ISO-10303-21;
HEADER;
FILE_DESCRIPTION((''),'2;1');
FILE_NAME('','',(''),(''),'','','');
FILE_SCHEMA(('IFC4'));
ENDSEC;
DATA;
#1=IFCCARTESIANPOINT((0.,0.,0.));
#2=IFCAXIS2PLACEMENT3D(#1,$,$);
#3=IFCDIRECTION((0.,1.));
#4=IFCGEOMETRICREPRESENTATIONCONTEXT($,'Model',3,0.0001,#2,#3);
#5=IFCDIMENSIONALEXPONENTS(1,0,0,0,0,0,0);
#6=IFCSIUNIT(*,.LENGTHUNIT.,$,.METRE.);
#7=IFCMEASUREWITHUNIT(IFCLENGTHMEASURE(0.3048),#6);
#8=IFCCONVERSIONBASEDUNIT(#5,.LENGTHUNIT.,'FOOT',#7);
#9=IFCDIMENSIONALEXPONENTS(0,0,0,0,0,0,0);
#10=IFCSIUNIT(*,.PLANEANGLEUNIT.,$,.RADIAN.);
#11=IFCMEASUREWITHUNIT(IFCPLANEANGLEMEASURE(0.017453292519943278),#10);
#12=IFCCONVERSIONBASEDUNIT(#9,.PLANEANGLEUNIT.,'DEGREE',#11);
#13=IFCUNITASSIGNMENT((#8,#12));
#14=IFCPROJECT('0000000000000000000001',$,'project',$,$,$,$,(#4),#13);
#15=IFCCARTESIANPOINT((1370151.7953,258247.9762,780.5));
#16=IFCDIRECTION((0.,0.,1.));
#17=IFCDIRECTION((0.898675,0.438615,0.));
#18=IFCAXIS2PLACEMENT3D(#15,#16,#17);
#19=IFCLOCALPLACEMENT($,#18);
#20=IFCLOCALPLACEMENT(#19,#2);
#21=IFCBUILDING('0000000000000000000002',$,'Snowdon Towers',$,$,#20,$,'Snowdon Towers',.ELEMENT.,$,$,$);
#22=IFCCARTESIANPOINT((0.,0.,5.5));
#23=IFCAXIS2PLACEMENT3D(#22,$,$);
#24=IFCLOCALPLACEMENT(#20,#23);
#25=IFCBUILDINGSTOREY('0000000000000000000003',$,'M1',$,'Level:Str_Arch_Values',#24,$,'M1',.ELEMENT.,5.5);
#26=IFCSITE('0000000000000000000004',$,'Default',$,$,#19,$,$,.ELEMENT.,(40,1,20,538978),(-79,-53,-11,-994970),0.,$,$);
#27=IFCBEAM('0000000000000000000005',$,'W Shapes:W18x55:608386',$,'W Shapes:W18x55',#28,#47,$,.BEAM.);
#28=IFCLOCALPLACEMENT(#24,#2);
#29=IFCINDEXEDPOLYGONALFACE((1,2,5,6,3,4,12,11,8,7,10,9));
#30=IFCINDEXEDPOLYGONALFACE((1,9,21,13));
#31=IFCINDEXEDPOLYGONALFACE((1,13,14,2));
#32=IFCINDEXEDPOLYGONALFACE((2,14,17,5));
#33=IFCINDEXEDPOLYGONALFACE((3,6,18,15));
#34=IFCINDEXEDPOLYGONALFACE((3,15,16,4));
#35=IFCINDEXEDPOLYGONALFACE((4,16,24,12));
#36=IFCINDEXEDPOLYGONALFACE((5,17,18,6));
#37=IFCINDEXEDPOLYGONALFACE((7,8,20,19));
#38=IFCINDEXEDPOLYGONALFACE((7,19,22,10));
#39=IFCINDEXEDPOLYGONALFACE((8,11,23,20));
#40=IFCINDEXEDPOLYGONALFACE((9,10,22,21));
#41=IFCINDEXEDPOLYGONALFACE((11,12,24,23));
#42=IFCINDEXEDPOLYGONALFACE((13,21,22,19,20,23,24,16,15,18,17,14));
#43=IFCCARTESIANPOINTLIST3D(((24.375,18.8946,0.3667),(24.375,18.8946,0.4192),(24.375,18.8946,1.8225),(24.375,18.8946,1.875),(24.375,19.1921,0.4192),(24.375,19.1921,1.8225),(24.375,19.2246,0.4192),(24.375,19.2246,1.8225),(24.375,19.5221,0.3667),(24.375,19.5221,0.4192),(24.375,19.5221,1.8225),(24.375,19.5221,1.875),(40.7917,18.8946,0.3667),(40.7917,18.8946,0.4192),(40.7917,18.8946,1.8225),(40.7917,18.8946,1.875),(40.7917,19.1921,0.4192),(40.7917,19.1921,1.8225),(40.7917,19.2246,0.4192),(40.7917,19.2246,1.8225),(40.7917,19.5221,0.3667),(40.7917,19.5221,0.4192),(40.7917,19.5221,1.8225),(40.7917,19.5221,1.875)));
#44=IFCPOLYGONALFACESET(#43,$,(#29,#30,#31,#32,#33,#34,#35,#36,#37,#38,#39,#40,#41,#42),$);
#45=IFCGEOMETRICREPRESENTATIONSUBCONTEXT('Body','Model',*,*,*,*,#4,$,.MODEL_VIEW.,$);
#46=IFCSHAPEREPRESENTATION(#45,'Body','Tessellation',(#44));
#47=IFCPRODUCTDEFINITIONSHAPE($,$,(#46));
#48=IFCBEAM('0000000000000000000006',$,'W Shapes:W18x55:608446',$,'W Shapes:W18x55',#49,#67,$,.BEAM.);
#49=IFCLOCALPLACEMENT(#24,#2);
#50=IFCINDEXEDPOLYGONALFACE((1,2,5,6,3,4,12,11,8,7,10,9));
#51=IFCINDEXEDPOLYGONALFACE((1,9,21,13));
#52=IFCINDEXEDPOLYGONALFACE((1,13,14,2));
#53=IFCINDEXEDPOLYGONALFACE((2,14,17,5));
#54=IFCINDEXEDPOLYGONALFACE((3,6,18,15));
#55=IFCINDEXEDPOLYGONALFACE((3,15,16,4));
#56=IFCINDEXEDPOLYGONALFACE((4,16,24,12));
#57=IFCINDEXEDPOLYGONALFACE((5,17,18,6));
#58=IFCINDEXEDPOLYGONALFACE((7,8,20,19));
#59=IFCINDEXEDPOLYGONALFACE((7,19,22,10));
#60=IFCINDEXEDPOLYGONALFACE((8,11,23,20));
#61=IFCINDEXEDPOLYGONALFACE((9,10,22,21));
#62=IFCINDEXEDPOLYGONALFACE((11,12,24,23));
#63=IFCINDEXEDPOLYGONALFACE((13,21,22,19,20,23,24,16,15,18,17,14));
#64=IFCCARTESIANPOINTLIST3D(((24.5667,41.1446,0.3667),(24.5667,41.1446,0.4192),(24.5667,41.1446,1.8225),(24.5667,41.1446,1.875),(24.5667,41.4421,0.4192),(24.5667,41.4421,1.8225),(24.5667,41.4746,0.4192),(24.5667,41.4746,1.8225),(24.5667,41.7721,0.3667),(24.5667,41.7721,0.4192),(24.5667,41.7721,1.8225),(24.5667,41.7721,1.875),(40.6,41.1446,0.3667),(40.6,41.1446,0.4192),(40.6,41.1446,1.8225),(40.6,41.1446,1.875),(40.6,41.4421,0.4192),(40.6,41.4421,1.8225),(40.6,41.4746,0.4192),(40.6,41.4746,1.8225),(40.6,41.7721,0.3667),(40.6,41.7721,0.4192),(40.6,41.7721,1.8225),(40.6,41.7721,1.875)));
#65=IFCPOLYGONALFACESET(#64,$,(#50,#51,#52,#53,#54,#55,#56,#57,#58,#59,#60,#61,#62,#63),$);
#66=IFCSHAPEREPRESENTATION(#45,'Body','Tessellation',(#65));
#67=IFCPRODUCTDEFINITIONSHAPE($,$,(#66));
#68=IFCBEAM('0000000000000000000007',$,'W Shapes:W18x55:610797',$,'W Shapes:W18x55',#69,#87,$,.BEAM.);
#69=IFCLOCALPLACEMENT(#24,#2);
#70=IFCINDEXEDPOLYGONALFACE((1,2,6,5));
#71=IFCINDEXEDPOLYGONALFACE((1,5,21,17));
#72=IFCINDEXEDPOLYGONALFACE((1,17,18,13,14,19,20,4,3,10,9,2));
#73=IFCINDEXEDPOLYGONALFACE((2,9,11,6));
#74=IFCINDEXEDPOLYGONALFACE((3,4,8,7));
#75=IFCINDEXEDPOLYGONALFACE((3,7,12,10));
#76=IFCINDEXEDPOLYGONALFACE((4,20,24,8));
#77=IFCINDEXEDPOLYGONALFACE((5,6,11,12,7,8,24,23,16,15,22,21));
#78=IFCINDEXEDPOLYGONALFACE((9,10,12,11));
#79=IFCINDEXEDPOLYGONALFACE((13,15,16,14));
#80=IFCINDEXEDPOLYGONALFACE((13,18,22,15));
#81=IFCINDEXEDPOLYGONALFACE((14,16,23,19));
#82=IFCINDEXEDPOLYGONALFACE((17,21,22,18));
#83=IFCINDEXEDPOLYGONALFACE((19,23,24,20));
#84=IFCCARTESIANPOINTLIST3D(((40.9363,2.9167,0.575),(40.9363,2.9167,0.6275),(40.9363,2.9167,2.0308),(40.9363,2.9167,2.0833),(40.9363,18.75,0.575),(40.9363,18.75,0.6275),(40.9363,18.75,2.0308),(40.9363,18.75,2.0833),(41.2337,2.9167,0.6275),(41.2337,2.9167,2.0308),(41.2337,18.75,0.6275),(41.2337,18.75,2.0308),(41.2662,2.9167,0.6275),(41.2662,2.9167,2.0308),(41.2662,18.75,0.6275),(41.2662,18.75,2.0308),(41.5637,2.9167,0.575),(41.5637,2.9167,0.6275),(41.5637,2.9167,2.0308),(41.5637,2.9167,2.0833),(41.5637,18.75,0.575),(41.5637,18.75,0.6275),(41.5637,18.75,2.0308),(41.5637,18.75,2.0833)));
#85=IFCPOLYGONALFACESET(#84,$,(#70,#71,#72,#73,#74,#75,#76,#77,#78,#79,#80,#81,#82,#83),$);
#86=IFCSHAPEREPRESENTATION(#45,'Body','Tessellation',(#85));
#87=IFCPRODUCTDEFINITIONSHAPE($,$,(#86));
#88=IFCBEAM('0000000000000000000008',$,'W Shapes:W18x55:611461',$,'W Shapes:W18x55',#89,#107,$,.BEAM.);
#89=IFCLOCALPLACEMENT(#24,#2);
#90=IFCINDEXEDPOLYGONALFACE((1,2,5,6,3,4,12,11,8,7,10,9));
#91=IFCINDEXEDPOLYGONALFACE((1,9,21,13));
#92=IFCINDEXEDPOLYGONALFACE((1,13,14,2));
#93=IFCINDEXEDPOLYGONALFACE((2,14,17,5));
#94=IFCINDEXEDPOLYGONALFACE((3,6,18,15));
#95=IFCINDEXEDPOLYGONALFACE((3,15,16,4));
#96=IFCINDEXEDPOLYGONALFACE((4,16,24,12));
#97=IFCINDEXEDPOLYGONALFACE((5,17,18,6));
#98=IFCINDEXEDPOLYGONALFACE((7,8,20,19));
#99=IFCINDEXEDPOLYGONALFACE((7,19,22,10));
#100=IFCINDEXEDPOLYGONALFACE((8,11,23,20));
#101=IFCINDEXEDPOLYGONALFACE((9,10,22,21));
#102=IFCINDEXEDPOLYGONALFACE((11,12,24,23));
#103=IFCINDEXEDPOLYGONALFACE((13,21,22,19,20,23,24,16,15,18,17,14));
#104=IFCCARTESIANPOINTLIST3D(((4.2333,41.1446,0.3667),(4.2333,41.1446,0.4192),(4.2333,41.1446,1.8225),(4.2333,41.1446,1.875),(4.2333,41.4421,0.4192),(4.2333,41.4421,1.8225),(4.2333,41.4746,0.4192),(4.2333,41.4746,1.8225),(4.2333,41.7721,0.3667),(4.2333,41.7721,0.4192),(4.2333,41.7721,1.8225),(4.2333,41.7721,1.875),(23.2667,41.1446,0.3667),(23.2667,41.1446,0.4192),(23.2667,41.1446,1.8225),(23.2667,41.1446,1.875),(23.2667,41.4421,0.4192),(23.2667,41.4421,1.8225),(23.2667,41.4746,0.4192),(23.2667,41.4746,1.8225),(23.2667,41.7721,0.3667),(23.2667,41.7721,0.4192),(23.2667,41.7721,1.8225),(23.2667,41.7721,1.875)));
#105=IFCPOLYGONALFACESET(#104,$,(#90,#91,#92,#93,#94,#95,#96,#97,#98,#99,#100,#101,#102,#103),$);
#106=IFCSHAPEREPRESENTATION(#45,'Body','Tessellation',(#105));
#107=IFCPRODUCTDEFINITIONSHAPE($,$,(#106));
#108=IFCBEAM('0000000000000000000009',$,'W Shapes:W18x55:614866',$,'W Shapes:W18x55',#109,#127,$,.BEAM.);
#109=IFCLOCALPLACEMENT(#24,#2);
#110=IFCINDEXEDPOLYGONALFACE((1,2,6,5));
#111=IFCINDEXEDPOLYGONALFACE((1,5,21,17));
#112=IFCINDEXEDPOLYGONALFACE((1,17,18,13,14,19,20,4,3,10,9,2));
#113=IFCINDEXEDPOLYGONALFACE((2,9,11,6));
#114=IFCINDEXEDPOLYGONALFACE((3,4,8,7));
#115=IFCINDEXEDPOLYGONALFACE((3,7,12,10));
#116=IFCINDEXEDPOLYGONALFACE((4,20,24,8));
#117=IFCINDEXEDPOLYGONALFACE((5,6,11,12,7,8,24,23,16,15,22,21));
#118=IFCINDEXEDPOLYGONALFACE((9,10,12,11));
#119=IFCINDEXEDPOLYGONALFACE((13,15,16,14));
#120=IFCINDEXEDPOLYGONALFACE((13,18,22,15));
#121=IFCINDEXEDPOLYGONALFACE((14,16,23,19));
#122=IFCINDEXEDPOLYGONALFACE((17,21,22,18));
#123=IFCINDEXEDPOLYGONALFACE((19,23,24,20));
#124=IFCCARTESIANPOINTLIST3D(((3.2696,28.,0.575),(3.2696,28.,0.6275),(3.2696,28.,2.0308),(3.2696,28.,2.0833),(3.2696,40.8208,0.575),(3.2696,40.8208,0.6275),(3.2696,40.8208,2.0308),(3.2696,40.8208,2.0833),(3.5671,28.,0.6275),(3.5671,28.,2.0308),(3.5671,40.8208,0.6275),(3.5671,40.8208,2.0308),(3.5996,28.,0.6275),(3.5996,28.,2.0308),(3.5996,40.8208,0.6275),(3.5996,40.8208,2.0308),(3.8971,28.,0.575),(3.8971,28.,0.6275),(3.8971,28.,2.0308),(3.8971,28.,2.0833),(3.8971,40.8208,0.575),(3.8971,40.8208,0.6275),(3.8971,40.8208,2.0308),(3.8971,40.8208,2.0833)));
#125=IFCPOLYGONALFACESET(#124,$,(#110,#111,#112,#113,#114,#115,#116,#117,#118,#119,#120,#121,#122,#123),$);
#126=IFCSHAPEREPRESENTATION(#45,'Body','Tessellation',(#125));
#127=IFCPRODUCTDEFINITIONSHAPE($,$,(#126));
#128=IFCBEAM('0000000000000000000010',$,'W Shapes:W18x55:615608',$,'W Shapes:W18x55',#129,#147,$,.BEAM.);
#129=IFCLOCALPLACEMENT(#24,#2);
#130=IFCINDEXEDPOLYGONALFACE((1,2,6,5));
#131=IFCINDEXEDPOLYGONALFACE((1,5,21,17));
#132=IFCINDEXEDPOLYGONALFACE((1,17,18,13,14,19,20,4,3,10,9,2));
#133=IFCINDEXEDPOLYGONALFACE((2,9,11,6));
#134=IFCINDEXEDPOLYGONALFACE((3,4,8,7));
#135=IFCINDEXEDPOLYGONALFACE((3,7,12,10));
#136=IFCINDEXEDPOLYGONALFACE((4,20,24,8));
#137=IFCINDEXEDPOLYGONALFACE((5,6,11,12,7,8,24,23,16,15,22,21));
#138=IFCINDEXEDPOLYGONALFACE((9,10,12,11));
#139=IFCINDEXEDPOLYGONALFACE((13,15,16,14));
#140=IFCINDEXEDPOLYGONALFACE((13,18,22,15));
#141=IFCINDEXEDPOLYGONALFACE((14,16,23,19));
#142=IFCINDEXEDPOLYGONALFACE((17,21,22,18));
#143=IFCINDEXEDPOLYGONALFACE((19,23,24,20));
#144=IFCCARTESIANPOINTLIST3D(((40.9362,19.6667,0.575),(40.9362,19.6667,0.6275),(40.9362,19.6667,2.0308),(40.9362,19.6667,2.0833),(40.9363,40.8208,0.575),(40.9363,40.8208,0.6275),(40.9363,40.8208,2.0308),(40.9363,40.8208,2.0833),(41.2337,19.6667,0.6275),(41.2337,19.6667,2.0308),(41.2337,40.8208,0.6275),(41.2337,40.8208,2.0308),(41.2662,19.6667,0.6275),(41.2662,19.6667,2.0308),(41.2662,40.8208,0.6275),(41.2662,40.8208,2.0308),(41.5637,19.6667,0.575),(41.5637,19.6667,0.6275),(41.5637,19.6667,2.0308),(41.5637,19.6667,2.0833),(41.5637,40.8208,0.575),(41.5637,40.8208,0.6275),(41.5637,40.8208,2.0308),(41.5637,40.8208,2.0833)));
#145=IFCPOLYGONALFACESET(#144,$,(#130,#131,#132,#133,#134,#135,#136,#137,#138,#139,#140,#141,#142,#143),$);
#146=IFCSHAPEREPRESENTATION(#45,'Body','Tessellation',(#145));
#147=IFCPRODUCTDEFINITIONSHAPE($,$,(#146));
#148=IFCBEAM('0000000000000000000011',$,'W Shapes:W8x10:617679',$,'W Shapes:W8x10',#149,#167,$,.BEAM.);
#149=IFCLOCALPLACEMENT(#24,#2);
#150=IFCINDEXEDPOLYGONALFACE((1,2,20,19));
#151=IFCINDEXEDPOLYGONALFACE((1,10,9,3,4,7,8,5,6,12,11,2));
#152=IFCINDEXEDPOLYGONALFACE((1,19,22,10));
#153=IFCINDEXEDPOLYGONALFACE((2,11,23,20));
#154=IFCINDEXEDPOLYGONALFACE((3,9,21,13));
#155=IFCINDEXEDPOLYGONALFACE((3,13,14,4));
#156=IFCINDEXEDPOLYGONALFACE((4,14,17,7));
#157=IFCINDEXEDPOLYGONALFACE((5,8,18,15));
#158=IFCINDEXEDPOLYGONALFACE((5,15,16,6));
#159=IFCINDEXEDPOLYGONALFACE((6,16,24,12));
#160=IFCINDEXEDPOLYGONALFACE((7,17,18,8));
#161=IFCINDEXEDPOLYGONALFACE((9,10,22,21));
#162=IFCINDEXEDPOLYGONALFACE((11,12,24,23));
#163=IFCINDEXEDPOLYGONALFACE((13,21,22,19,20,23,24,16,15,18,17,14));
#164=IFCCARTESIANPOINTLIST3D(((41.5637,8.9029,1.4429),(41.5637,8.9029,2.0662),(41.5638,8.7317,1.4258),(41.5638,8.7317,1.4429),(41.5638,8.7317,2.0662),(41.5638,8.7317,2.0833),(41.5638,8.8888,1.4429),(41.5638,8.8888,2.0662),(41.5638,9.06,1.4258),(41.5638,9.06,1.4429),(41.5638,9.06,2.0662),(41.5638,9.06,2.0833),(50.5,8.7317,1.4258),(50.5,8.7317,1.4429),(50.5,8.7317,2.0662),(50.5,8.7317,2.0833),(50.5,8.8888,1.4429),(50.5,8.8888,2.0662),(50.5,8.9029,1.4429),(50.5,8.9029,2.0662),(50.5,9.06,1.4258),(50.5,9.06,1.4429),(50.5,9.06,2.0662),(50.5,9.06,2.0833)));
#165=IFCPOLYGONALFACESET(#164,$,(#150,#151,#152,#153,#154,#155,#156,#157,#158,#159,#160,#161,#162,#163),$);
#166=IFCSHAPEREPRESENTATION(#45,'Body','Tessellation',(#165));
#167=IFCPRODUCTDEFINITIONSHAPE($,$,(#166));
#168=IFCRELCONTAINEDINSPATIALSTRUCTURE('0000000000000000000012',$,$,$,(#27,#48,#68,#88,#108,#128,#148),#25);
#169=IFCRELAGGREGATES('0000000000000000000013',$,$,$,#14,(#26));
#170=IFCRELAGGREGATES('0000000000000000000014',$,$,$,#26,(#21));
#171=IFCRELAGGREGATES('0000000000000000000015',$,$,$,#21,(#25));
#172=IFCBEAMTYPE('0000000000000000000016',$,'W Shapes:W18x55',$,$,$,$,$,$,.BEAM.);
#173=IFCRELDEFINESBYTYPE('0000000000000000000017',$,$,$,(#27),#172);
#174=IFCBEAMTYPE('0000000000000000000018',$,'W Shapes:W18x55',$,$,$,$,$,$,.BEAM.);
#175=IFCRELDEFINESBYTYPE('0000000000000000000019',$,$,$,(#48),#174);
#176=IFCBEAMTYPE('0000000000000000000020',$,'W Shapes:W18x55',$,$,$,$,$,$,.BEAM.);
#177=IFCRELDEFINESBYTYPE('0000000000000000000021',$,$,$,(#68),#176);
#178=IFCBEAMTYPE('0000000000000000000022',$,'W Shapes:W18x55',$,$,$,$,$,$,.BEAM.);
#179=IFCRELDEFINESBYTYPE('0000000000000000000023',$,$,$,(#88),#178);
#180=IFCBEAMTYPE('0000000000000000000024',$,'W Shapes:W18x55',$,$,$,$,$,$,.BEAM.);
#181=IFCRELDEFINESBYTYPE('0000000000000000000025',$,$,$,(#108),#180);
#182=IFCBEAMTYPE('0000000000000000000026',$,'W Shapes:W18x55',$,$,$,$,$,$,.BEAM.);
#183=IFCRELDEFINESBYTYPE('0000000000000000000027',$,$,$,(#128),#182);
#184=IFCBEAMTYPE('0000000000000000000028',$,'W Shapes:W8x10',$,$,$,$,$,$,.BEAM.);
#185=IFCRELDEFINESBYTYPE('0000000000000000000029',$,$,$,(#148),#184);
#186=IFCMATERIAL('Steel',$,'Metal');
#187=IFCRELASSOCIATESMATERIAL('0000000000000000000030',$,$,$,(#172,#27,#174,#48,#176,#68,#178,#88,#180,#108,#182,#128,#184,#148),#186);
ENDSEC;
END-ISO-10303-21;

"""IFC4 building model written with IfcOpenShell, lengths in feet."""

from ifc_helpers import new_model, entity, si_unit, converted_unit, direction, frame, origin, place, context, subcontext, project, spatial, indexed_curve, outline, extrude, source, transform, mapped, material, type_object, type_shapes, element, save


model = new_model("IFC4")

# Units and contexts
model_context = context("Model", 3, precision=0.0001, world=origin(), true_north=direction((0.0, 1.0)))
body_context = subcontext(model_context, "Body", "Model", "MODEL_VIEW")
ifc_project = project(units=[converted_unit("LENGTHUNIT", "FOOT", entity("IfcLengthMeasure", 0.3048), si_unit("LENGTHUNIT", "METRE"), dimensions=[1, 0, 0, 0, 0, 0, 0]), converted_unit("PLANEANGLEUNIT", "DEGREE", entity("IfcPlaneAngleMeasure", 0.017453292519943278), si_unit("PLANEANGLEUNIT", "RADIAN"), dimensions=[0, 0, 0, 0, 0, 0, 0])], contexts=[model_context])

# Site, building, storey
site_placement = place(None, frame((1370151.7953, 258247.9762, 780.5), z_axis=(0.0, 0.0, 1.0), x_axis=(0.898675, 0.438615, 0.0)))
site = spatial("IfcSite", under=ifc_project, at=site_placement, Name="Default", CompositionType="ELEMENT", RefLatitude=(40, 1, 20, 538978), RefLongitude=(-79, -53, -11, -994970), RefElevation=0.0)
building_placement = place(site_placement, origin())
building = spatial("IfcBuilding", under=site, at=building_placement, Name="Snowdon Towers", LongName="Snowdon Towers", CompositionType="ELEMENT")
storey_placement = place(building_placement, frame((0.0, 0.0, 5.5)))
storey = spatial("IfcBuildingStorey", under=building, at=storey_placement, Name="M1", ObjectType="Level:Str_Arch_Values", LongName="M1", CompositionType="ELEMENT", Elevation=5.5)

# Beams
ifc_material = material(Name="Steel", Category="Metal")
beam_type_1 = type_object("IfcBeamType", Name="W Shapes:W18x55", PredefinedType="BEAM", material=ifc_material)
shared_shape_1 = source(origin(), body_context, "Body", "SweptSolid", [
    extrude(outline(indexed_curve([(-0.3138, -0.7017), (-0.3138, -0.7542), (0.3138, -0.7542), (0.3138, -0.7017), (0.0162, -0.7017), (0.0162, 0.7017), (0.3138, 0.7017), (0.3138, 0.7542), (-0.3137, 0.7542), (-0.3137, 0.7017), (-0.0163, 0.7017), (-0.0163, -0.7017), (-0.3138, -0.7017)], self_intersect=False)), frame((-8.2083, 0.0, 0.0), z_axis=(-1.0, 0.0, 0.0), x_axis=(0.0, -1.0, 0.0)), (0.0, 0.0, -1.0), 16.4167),
])
type_shapes(beam_type_1, [shared_shape_1])
beam_1_placement = place(storey_placement, frame((32.5833, 19.2083, 1.1208)))
element("IfcBeam", 1, at=beam_1_placement, inside=storey, type_object=beam_type_1, material=ifc_material, Name="W Shapes:W18x55:608386", ObjectType="W Shapes:W18x55", PredefinedType="BEAM", context=body_context, shape_type="MappedRepresentation", body=[
    mapped(shared_shape_1, transform((0.0, 0.0, 0.0), scale=1.0)),
])
beam_type_2 = type_object("IfcBeamType", Name="W Shapes:W18x55", PredefinedType="BEAM", material=ifc_material)
shared_shape_2 = source(origin(), body_context, "Body", "SweptSolid", [
    extrude(outline(indexed_curve([(-0.3138, -0.7017), (-0.3138, -0.7542), (0.3138, -0.7542), (0.3138, -0.7017), (0.0162, -0.7017), (0.0162, 0.7017), (0.3138, 0.7017), (0.3138, 0.7542), (-0.3137, 0.7542), (-0.3137, 0.7017), (-0.0163, 0.7017), (-0.0163, -0.7017), (-0.3138, -0.7017)], self_intersect=False)), frame((-8.0167, 0.0, 0.0), z_axis=(-1.0, 0.0, 0.0), x_axis=(0.0, -1.0, 0.0)), (0.0, 0.0, -1.0), 16.0333),
])
type_shapes(beam_type_2, [shared_shape_2])
beam_2_placement = place(storey_placement, frame((32.5833, 41.4583, 1.1208)))
element("IfcBeam", 2, at=beam_2_placement, inside=storey, type_object=beam_type_2, material=ifc_material, Name="W Shapes:W18x55:608446", ObjectType="W Shapes:W18x55", PredefinedType="BEAM", context=body_context, shape_type="MappedRepresentation", body=[
    mapped(shared_shape_2, transform((0.0, 0.0, 0.0), scale=1.0)),
])

# Beams
beam_type_3 = type_object("IfcBeamType", Name="W Shapes:W18x55", PredefinedType="BEAM", material=ifc_material)
shared_shape_3 = source(origin(), body_context, "Body", "SweptSolid", [
    extrude(outline(indexed_curve([(-0.3138, -0.7017), (-0.3138, -0.7542), (0.3138, -0.7542), (0.3138, -0.7017), (0.0162, -0.7017), (0.0162, 0.7017), (0.3138, 0.7017), (0.3138, 0.7542), (-0.3137, 0.7542), (-0.3137, 0.7017), (-0.0163, 0.7017), (-0.0163, -0.7017), (-0.3138, -0.7017)], self_intersect=False)), frame((-7.875, 0.0, 0.0), z_axis=(-1.0, 0.0, 0.0), x_axis=(0.0, -1.0, 0.0)), (0.0, 0.0, -1.0), 15.8333),
])
type_shapes(beam_type_3, [shared_shape_3])
beam_3_placement = place(storey_placement, frame((41.25, 10.7917, 1.3292), z_axis=(0.0, 0.0, 1.0), x_axis=(0.0, 1.0, 0.0)))
element("IfcBeam", 3, at=beam_3_placement, inside=storey, type_object=beam_type_3, material=ifc_material, Name="W Shapes:W18x55:610797", ObjectType="W Shapes:W18x55", PredefinedType="BEAM", context=body_context, shape_type="MappedRepresentation", body=[
    mapped(shared_shape_3, transform((0.0, 0.0, 0.0), scale=1.0)),
])
beam_type_4 = type_object("IfcBeamType", Name="W Shapes:W18x55", PredefinedType="BEAM", material=ifc_material)
shared_shape_4 = source(origin(), body_context, "Body", "SweptSolid", [
    extrude(outline(indexed_curve([(-0.3138, -0.7017), (-0.3138, -0.7542), (0.3138, -0.7542), (0.3138, -0.7017), (0.0162, -0.7017), (0.0162, 0.7017), (0.3138, 0.7017), (0.3138, 0.7542), (-0.3137, 0.7542), (-0.3137, 0.7017), (-0.0163, 0.7017), (-0.0163, -0.7017), (-0.3138, -0.7017)], self_intersect=False)), frame((-9.6, 0.0, 0.0), z_axis=(-1.0, 0.0, 0.0), x_axis=(0.0, -1.0, 0.0)), (0.0, 0.0, -1.0), 19.0333),
])
type_shapes(beam_type_4, [shared_shape_4])
beam_4_placement = place(storey_placement, frame((13.8333, 41.4583, 1.1208)))
element("IfcBeam", 4, at=beam_4_placement, inside=storey, type_object=beam_type_4, material=ifc_material, Name="W Shapes:W18x55:611461", ObjectType="W Shapes:W18x55", PredefinedType="BEAM", context=body_context, shape_type="MappedRepresentation", body=[
    mapped(shared_shape_4, transform((0.0, 0.0, 0.0), scale=1.0)),
])
beam_type_5 = type_object("IfcBeamType", Name="W Shapes:W18x55", PredefinedType="BEAM", material=ifc_material)
shared_shape_5 = source(origin(), body_context, "Body", "SweptSolid", [
    extrude(outline(indexed_curve([(-0.3138, -0.7017), (-0.3138, -0.7542), (0.3138, -0.7542), (0.3138, -0.7017), (0.0162, -0.7017), (0.0162, 0.7017), (0.3138, 0.7017), (0.3138, 0.7542), (-0.3137, 0.7542), (-0.3137, 0.7017), (-0.0163, 0.7017), (-0.0163, -0.7017), (-0.3138, -0.7017)], self_intersect=False)), frame((-6.5833, 0.0, 0.0), z_axis=(-1.0, 0.0, 0.0), x_axis=(0.0, -1.0, 0.0)), (0.0, 0.0, -1.0), 12.8208),
])
type_shapes(beam_type_5, [shared_shape_5])
beam_5_placement = place(storey_placement, frame((3.5833, 34.5833, 1.3292), z_axis=(0.0, 0.0, 1.0), x_axis=(0.0, 1.0, 0.0)))
element("IfcBeam", 5, at=beam_5_placement, inside=storey, type_object=beam_type_5, material=ifc_material, Name="W Shapes:W18x55:614866", ObjectType="W Shapes:W18x55", PredefinedType="BEAM", context=body_context, shape_type="MappedRepresentation", body=[
    mapped(shared_shape_5, transform((0.0, 0.0, 0.0), scale=1.0)),
])
beam_type_6 = type_object("IfcBeamType", Name="W Shapes:W18x55", PredefinedType="BEAM", material=ifc_material)
shared_shape_6 = source(origin(), body_context, "Body", "SweptSolid", [
    extrude(outline(indexed_curve([(-0.3138, -0.7017), (-0.3138, -0.7542), (0.3138, -0.7542), (0.3138, -0.7017), (0.0162, -0.7017), (0.0162, 0.7017), (0.3138, 0.7017), (0.3138, 0.7542), (-0.3137, 0.7542), (-0.3137, 0.7017), (-0.0163, 0.7017), (-0.0163, -0.7017), (-0.3138, -0.7017)], self_intersect=False)), frame((-10.75, 0.0, 0.0), z_axis=(-1.0, 0.0, 0.0), x_axis=(0.0, -1.0, 0.0)), (0.0, 0.0, -1.0), 21.1542),
])
type_shapes(beam_type_6, [shared_shape_6])
beam_6_placement = place(storey_placement, frame((41.25, 30.4167, 1.3292), z_axis=(0.0, 0.0, 1.0), x_axis=(0.0, 1.0, 0.0)))
element("IfcBeam", 6, at=beam_6_placement, inside=storey, type_object=beam_type_6, material=ifc_material, Name="W Shapes:W18x55:615608", ObjectType="W Shapes:W18x55", PredefinedType="BEAM", context=body_context, shape_type="MappedRepresentation", body=[
    mapped(shared_shape_6, transform((0.0, 0.0, 0.0), scale=1.0)),
])
beam_type_7 = type_object("IfcBeamType", Name="W Shapes:W8x10", PredefinedType="BEAM", material=ifc_material)
shared_shape_7 = source(origin(), body_context, "Body", "SweptSolid", [
    extrude(outline(indexed_curve([(-0.1642, -0.3117), (-0.1642, -0.3288), (0.1642, -0.3288), (0.1642, -0.3117), (0.0071, -0.3117), (0.0071, 0.3117), (0.1642, 0.3117), (0.1642, 0.3287), (-0.1642, 0.3287), (-0.1642, 0.3117), (-0.0071, 0.3117), (-0.0071, -0.3117), (-0.1642, -0.3117)], self_intersect=False)), frame((-4.4792, 0.0, 0.0), z_axis=(-1.0, 0.0, 0.0), x_axis=(0.0, -1.0, 0.0)), (0.0, 0.0, -1.0), 8.9362),
])
type_shapes(beam_type_7, [shared_shape_7])
beam_7_placement = place(storey_placement, frame((46.0208, 8.8958, 1.7546), z_axis=(0.0, 0.0, 1.0), x_axis=(-1.0, 0.0, 0.0)))
element("IfcBeam", 7, at=beam_7_placement, inside=storey, type_object=beam_type_7, material=ifc_material, Name="W Shapes:W8x10:617679", ObjectType="W Shapes:W8x10", PredefinedType="BEAM", context=body_context, shape_type="MappedRepresentation", body=[
    mapped(shared_shape_7, transform((0.0, 0.0, 0.0), scale=1.0)),
])

save(model, "model.ifc")
